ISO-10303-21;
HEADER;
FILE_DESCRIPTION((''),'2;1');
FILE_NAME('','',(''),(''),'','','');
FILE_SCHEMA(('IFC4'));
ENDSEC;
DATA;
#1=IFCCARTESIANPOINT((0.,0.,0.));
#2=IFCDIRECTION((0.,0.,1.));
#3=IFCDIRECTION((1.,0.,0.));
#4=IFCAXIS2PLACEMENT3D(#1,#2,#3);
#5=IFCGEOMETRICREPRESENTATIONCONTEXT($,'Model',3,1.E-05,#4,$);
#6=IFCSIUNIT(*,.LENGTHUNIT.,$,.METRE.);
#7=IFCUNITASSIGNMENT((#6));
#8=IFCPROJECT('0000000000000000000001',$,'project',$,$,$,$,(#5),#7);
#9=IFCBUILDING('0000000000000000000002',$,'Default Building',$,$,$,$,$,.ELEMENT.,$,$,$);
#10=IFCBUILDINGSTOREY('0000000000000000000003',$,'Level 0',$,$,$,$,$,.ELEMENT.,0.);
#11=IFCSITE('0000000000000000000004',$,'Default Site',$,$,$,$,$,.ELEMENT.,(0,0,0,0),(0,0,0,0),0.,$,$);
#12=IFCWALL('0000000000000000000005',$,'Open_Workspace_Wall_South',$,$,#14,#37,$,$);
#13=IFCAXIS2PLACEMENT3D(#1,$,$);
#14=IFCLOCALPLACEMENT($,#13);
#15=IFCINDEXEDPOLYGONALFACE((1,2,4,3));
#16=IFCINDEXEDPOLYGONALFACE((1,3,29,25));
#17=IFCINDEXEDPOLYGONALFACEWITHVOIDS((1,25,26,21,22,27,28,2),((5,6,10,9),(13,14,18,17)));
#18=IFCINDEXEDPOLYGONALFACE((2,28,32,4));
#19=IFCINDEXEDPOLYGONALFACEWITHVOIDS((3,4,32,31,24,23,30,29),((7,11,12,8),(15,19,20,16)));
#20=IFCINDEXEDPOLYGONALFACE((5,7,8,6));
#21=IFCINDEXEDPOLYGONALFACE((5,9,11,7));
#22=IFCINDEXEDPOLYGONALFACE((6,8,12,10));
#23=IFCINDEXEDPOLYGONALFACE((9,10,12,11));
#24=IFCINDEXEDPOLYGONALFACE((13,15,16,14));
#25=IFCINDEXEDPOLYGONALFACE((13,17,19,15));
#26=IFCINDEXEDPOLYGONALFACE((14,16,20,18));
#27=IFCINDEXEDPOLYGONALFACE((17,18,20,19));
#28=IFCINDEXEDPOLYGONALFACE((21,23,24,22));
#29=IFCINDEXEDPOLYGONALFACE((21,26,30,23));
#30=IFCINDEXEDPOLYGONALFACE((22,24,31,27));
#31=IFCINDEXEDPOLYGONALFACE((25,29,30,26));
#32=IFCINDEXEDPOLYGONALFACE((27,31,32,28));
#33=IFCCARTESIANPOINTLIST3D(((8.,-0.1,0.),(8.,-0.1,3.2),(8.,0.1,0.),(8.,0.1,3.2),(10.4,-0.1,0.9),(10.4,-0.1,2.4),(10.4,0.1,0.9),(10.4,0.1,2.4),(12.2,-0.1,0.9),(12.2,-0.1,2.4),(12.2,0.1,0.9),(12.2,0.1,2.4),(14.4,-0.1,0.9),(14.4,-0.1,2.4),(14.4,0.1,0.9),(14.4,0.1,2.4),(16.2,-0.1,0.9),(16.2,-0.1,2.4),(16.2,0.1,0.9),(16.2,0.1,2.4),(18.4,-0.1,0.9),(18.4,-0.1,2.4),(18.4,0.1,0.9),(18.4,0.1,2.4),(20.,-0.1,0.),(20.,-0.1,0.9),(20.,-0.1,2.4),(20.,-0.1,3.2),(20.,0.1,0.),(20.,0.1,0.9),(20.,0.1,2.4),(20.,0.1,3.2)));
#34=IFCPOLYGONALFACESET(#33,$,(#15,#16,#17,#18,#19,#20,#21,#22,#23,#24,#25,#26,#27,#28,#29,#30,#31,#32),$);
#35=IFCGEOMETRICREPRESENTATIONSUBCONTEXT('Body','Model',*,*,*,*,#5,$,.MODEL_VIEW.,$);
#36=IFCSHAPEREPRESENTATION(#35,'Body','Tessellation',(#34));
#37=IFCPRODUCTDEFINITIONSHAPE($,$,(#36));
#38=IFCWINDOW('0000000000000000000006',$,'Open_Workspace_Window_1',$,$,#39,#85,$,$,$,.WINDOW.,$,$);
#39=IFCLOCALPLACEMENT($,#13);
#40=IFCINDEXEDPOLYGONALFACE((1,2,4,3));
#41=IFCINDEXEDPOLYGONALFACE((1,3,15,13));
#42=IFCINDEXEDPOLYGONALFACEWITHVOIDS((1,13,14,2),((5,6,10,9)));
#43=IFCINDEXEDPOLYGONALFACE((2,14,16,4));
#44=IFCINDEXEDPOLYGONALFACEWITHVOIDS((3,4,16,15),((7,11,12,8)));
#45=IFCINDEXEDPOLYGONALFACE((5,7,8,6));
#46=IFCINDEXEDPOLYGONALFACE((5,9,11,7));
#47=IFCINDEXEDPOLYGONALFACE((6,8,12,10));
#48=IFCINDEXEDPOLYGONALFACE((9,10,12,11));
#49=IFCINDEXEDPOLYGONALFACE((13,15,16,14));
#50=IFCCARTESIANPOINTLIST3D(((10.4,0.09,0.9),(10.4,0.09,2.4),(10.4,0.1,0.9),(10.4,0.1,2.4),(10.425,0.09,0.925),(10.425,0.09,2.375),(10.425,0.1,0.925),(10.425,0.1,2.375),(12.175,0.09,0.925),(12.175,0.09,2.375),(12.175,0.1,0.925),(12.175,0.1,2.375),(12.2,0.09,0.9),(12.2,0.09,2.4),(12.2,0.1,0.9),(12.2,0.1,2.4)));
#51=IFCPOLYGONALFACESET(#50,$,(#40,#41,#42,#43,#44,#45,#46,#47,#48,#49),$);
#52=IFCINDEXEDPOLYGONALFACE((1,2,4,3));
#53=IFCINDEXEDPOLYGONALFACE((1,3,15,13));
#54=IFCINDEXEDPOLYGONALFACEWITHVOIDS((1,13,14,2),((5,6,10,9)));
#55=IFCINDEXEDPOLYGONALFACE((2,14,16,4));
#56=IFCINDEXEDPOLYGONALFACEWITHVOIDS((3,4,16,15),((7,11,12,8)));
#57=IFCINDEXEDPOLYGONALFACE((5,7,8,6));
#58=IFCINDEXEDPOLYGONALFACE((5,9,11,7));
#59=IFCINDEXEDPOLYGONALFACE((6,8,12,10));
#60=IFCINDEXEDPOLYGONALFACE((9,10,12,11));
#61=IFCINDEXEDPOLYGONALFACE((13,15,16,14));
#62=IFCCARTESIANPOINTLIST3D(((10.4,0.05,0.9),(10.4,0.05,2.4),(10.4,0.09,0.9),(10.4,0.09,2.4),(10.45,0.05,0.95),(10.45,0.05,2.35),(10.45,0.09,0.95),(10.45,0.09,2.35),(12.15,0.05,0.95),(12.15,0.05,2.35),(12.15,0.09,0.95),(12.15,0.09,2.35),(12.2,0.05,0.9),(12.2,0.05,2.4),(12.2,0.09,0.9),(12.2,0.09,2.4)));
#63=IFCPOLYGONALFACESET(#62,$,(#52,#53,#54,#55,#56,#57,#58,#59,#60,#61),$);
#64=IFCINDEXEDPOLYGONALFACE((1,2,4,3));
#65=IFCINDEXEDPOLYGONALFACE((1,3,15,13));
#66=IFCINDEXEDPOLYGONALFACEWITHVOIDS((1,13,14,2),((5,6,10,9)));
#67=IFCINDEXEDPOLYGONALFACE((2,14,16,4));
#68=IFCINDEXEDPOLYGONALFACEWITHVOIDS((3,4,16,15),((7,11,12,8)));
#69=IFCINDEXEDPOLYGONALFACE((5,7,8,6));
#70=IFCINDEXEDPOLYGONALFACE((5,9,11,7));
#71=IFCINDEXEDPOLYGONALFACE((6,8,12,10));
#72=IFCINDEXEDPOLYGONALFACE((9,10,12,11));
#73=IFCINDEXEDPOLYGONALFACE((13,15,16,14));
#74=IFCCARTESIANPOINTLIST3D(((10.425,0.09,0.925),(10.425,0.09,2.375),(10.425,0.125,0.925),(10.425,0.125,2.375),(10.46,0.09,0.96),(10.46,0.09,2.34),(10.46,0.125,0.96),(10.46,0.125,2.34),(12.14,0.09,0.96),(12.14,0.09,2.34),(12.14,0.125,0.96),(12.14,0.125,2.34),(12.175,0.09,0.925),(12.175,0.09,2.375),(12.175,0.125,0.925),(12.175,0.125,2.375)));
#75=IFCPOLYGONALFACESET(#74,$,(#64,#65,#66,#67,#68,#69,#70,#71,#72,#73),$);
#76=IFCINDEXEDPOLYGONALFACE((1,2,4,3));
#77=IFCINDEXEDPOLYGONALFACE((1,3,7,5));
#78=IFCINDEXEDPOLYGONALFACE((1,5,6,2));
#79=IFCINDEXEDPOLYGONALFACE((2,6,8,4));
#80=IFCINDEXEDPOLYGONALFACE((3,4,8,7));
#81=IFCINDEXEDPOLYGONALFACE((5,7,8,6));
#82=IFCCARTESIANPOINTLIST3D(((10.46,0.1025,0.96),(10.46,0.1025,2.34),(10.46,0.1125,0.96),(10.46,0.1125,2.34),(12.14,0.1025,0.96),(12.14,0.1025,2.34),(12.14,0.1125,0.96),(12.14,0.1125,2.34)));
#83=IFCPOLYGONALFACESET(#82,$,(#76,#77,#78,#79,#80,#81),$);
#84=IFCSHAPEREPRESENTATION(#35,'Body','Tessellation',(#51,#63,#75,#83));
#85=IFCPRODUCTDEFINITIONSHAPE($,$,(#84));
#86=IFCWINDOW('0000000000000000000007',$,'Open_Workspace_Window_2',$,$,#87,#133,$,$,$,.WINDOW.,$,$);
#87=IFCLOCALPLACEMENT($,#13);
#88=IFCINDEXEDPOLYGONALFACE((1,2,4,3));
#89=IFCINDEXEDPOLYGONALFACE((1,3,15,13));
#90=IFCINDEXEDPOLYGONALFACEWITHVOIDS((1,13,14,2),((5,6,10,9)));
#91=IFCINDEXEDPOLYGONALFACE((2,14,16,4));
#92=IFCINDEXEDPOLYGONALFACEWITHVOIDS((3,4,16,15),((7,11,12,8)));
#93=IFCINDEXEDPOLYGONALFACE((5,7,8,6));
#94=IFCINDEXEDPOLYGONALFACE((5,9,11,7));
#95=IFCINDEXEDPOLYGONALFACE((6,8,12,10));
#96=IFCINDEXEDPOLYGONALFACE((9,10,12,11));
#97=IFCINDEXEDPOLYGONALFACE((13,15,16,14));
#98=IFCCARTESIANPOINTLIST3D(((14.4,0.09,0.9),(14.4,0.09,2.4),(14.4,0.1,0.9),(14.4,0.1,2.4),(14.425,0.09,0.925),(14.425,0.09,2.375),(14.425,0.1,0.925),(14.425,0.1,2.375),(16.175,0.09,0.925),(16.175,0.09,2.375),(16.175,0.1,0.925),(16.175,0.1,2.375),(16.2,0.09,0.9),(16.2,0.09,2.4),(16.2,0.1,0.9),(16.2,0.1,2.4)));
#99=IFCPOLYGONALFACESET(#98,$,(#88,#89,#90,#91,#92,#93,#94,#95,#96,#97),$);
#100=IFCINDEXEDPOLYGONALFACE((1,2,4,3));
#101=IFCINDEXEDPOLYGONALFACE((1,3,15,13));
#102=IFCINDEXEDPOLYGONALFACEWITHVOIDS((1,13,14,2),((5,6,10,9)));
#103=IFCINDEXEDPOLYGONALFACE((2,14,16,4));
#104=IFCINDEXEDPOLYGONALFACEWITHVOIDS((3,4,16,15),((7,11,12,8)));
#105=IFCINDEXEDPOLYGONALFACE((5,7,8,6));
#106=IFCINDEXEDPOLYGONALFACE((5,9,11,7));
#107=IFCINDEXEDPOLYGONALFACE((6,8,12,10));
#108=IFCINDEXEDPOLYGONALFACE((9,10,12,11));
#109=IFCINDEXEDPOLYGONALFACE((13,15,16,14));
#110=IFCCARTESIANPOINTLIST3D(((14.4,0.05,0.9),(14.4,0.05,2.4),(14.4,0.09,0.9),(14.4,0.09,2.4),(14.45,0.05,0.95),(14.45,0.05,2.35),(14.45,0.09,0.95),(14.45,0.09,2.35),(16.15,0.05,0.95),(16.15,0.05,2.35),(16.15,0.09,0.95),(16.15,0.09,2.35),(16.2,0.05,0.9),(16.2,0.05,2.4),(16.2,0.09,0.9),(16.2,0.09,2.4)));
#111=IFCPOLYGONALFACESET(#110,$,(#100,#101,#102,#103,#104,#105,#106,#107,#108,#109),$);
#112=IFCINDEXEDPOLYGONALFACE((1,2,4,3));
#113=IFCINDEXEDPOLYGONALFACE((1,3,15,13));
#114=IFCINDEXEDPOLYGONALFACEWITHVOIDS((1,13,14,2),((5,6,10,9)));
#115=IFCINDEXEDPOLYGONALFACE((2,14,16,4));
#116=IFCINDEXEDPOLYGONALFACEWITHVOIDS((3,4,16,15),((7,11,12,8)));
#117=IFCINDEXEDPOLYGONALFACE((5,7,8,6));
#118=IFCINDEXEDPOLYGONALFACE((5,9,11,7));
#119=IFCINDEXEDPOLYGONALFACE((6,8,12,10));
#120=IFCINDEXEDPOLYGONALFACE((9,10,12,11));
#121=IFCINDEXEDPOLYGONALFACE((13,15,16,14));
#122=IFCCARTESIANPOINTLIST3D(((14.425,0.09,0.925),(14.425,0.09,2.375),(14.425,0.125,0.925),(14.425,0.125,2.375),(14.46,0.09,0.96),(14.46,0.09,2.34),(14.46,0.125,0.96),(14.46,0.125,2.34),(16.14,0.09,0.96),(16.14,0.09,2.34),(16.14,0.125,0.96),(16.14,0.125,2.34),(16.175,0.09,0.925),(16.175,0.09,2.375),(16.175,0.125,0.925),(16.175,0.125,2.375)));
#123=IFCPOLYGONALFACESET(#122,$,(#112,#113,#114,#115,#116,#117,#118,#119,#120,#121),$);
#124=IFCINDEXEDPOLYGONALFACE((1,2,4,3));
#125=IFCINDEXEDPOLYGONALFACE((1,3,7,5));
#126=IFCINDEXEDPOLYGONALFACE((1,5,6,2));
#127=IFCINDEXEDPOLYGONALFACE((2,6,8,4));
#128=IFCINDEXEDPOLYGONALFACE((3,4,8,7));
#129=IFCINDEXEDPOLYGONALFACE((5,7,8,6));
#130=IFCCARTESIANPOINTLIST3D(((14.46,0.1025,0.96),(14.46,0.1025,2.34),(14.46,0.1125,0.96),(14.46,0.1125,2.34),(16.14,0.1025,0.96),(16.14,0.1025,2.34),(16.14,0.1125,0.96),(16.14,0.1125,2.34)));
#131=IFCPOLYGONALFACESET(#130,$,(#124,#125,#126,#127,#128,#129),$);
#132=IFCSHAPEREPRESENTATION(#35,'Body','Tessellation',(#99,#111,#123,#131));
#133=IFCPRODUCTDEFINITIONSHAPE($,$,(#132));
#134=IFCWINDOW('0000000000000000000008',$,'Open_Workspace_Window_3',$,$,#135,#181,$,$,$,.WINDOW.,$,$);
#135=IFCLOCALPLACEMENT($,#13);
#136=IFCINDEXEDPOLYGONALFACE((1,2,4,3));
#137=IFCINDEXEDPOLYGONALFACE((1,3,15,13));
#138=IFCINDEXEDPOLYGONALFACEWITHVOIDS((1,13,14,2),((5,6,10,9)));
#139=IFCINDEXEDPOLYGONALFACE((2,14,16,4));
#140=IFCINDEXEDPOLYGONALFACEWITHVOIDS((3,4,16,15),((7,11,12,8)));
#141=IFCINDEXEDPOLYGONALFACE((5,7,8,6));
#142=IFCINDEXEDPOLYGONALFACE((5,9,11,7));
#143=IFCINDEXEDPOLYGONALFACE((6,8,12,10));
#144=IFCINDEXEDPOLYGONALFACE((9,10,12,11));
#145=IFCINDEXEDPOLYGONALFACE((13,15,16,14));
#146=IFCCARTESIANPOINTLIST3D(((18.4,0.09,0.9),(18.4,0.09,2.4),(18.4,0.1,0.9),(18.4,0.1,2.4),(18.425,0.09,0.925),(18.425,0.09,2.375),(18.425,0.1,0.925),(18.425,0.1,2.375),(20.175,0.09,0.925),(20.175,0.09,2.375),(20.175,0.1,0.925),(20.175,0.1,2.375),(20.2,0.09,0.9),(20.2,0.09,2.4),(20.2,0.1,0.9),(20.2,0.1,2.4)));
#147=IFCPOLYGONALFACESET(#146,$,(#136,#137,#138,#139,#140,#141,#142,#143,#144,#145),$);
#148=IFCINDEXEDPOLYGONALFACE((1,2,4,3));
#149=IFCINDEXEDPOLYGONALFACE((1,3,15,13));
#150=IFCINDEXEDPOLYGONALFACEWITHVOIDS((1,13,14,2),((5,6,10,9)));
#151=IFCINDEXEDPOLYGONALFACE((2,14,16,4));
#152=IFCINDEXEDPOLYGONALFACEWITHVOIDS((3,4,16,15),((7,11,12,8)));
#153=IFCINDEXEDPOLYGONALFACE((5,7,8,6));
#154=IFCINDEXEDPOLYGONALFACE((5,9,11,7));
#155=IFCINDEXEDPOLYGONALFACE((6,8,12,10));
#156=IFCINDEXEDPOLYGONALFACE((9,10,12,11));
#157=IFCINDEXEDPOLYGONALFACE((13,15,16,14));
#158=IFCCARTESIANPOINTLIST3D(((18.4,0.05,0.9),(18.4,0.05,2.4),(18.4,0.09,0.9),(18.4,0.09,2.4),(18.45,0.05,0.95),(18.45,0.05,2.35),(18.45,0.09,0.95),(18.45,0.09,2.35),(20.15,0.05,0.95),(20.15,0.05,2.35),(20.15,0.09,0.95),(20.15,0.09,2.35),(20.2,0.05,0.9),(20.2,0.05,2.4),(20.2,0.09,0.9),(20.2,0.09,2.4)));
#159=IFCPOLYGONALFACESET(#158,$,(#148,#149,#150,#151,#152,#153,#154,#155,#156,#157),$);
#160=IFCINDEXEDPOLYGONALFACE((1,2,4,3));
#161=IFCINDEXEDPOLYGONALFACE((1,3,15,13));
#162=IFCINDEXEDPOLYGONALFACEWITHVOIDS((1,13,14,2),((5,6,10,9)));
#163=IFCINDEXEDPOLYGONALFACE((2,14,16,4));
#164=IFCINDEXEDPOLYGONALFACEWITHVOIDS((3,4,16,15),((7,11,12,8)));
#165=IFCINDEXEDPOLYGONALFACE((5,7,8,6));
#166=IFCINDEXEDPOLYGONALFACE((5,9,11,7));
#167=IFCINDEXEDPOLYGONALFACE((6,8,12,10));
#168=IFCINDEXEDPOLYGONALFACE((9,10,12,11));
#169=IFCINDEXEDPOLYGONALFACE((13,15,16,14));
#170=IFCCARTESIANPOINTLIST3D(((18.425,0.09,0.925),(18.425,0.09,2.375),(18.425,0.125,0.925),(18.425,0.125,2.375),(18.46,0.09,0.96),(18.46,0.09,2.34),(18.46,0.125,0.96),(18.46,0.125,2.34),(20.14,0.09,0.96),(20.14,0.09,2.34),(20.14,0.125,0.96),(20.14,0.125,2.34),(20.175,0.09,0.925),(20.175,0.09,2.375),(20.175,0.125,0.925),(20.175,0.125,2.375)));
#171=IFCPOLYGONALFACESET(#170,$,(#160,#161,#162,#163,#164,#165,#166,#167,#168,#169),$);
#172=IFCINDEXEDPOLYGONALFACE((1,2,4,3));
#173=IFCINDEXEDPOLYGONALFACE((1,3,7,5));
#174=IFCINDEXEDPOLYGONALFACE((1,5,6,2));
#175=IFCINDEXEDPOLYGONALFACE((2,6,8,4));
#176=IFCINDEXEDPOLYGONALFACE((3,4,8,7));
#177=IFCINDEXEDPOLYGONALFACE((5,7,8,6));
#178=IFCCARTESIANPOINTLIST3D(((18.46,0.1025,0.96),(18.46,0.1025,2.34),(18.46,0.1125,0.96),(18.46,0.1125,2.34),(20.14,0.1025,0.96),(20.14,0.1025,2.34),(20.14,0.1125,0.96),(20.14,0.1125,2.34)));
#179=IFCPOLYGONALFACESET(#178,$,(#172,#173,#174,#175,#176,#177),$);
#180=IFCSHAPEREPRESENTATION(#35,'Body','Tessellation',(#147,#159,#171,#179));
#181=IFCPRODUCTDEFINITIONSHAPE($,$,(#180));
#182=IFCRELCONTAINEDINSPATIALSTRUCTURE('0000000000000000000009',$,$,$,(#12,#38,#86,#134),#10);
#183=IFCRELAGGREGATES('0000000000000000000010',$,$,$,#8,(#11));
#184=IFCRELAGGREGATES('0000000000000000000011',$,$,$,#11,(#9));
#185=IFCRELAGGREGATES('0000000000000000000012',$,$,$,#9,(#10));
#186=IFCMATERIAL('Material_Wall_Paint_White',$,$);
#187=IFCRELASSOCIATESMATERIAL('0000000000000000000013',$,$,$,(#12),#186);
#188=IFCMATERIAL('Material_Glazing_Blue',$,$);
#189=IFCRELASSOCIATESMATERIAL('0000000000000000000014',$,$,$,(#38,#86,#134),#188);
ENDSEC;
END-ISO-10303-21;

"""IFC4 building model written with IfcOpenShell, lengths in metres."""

from ifc_helpers import new_model, si_unit, frame, origin_with_axes, place, context, subcontext, project, spatial, line, indexed_curve, outline, extrude, material, element, fill, save


model = new_model("IFC4")

# Units and contexts
model_context = context("Model", 3, precision=1e-05, world=origin_with_axes())
body_context = subcontext(model_context, "Body", "Model", "MODEL_VIEW")
ifc_project = project(units=[si_unit("LENGTHUNIT", "METRE")], contexts=[model_context])

# Site, building, storey
site = spatial("IfcSite", under=ifc_project, Name="Default Site", CompositionType="ELEMENT", RefLatitude=(0, 0, 0, 0), RefLongitude=(0, 0, 0, 0), RefElevation=0.0)
building = spatial("IfcBuilding", under=site, Name="Default Building", CompositionType="ELEMENT")
storey = spatial("IfcBuildingStorey", under=building, Name="Level 0", CompositionType="ELEMENT", Elevation=0.0)

# Shared definitions
ifc_material_1 = material(Name="Material_Wall_Paint_White")

# Wall, openings, windows
wall_1_placement = place(None, frame((8.0, 0.0, 0.0), z_axis=(0.0, 0.0, 1.0), x_axis=(1.0, 0.0, 0.0)))
wall_1 = element("IfcWall", 1, at=wall_1_placement, inside=storey, material=ifc_material_1, Name="Open_Workspace_Wall_South", context=body_context, shape_type="SweptSolid", body=[
    extrude(outline(indexed_curve([(0.0, 0.0), (0.0, 0.2), (12.0, 0.2), (12.0, 0.0), (0.0, 0.0)], self_intersect=False)), frame((0.0, -0.1, 0.0), z_axis=(0.0, 0.0, 1.0), x_axis=(1.0, 0.0, 0.0)), (0.0, 0.0, 1.0), 3.2),
])
opening_1_placement = place(wall_1_placement, frame((2.4, -0.5, 0.9), z_axis=(0.0, 0.0, 1.0), x_axis=(1.0, 0.0, 0.0)))
opening_1 = element("IfcOpeningElement", 2, at=opening_1_placement, inside=storey, cuts=wall_1, PredefinedType="OPENING", context=body_context, shape_type="SweptSolid", body=[
    extrude(outline(indexed_curve([(0.0, 0.0), (0.0, 1.0), (1.8, 1.0), (1.8, 0.0), (0.0, 0.0)], self_intersect=False)), origin_with_axes(), (0.0, 0.0, 1.0), 1.5),
])
opening_2_placement = place(wall_1_placement, frame((6.4, -0.5, 0.9), z_axis=(0.0, 0.0, 1.0), x_axis=(1.0, 0.0, 0.0)))
opening_2 = element("IfcOpeningElement", 3, at=opening_2_placement, inside=storey, cuts=wall_1, PredefinedType="OPENING", context=body_context, shape_type="SweptSolid", body=[
    extrude(outline(indexed_curve([(0.0, 0.0), (0.0, 1.0), (1.8, 1.0), (1.8, 0.0), (0.0, 0.0)], self_intersect=False)), origin_with_axes(), (0.0, 0.0, 1.0), 1.5),
])
opening_3_placement = place(wall_1_placement, frame((10.4, -0.5, 0.9), z_axis=(0.0, 0.0, 1.0), x_axis=(1.0, 0.0, 0.0)))
opening_3 = element("IfcOpeningElement", 4, at=opening_3_placement, inside=storey, cuts=wall_1, PredefinedType="OPENING", context=body_context, shape_type="SweptSolid", body=[
    extrude(outline(indexed_curve([(0.0, 0.0), (0.0, 1.0), (1.8, 1.0), (1.8, 0.0), (0.0, 0.0)], self_intersect=False)), origin_with_axes(), (0.0, 0.0, 1.0), 1.5),
])
ifc_material_2 = material(Name="Material_Glazing_Blue")
window_1_placement = place(None, frame((10.4, 0.0, 0.9), z_axis=(0.0, 0.0, 1.0), x_axis=(1.0, 0.0, 0.0)))
window_1 = element("IfcWindow", 5, at=window_1_placement, inside=storey, material=ifc_material_2, Name="Open_Workspace_Window_1", PredefinedType="WINDOW", context=body_context, shape_type="SweptSolid", body=[
    extrude(outline(indexed_curve([(0.0, 0.0), (1.8, 0.0), (1.8, 1.5), (0.0, 1.5)], segments=[line(1, 2, 3, 4, 1)]), holes=[indexed_curve([(0.025, 0.025), (1.775, 0.025), (1.775, 1.475), (0.025, 1.475)], segments=[line(1, 2, 3, 4, 1)])]), frame((0.0, 0.09, 0.0), z_axis=(0.0, -1.0, 0.0), x_axis=(1.0, 0.0, 0.0)), (0.0, 0.0, -1.0), 0.01),
    extrude(outline(indexed_curve([(0.0, 0.0), (1.8, 0.0), (1.8, 1.5), (0.0, 1.5)], segments=[line(1, 2, 3, 4, 1)]), holes=[indexed_curve([(0.05, 0.05), (1.75, 0.05), (1.75, 1.45), (0.05, 1.45)], segments=[line(1, 2, 3, 4, 1)])]), frame((0.0, 0.05, 0.0), z_axis=(0.0, -1.0, 0.0), x_axis=(1.0, 0.0, 0.0)), (0.0, 0.0, -1.0), 0.04),
    extrude(outline(indexed_curve([(0.0, 0.0), (1.75, 0.0), (1.75, 1.45), (0.0, 1.45)], segments=[line(1, 2, 3, 4, 1)]), holes=[indexed_curve([(0.035, 0.035), (1.715, 0.035), (1.715, 1.415), (0.035, 1.415)], segments=[line(1, 2, 3, 4, 1)])]), frame((0.025, 0.09, 0.025), z_axis=(0.0, -1.0, 0.0), x_axis=(1.0, 0.0, 0.0)), (0.0, 0.0, -1.0), 0.035),
    extrude(outline(indexed_curve([(0.035, 0.035), (1.715, 0.035), (1.715, 1.415), (0.035, 1.415)], segments=[line(1, 2, 3, 4, 1)])), frame((0.025, 0.1025, 0.025), z_axis=(0.0, -1.0, 0.0), x_axis=(1.0, 0.0, 0.0)), (0.0, 0.0, -1.0), 0.01),
])
fill(opening_1, window_1)
window_2_placement = place(None, frame((14.4, 0.0, 0.9), z_axis=(0.0, 0.0, 1.0), x_axis=(1.0, 0.0, 0.0)))
window_2 = element("IfcWindow", 6, at=window_2_placement, inside=storey, material=ifc_material_2, Name="Open_Workspace_Window_2", PredefinedType="WINDOW", context=body_context, shape_type="SweptSolid", body=[
    extrude(outline(indexed_curve([(0.0, 0.0), (1.8, 0.0), (1.8, 1.5), (0.0, 1.5)], segments=[line(1, 2, 3, 4, 1)]), holes=[indexed_curve([(0.025, 0.025), (1.775, 0.025), (1.775, 1.475), (0.025, 1.475)], segments=[line(1, 2, 3, 4, 1)])]), frame((0.0, 0.09, 0.0), z_axis=(0.0, -1.0, 0.0), x_axis=(1.0, 0.0, 0.0)), (0.0, 0.0, -1.0), 0.01),
    extrude(outline(indexed_curve([(0.0, 0.0), (1.8, 0.0), (1.8, 1.5), (0.0, 1.5)], segments=[line(1, 2, 3, 4, 1)]), holes=[indexed_curve([(0.05, 0.05), (1.75, 0.05), (1.75, 1.45), (0.05, 1.45)], segments=[line(1, 2, 3, 4, 1)])]), frame((0.0, 0.05, 0.0), z_axis=(0.0, -1.0, 0.0), x_axis=(1.0, 0.0, 0.0)), (0.0, 0.0, -1.0), 0.04),
    extrude(outline(indexed_curve([(0.0, 0.0), (1.75, 0.0), (1.75, 1.45), (0.0, 1.45)], segments=[line(1, 2, 3, 4, 1)]), holes=[indexed_curve([(0.035, 0.035), (1.715, 0.035), (1.715, 1.415), (0.035, 1.415)], segments=[line(1, 2, 3, 4, 1)])]), frame((0.025, 0.09, 0.025), z_axis=(0.0, -1.0, 0.0), x_axis=(1.0, 0.0, 0.0)), (0.0, 0.0, -1.0), 0.035),
    extrude(outline(indexed_curve([(0.035, 0.035), (1.715, 0.035), (1.715, 1.415), (0.035, 1.415)], segments=[line(1, 2, 3, 4, 1)])), frame((0.025, 0.1025, 0.025), z_axis=(0.0, -1.0, 0.0), x_axis=(1.0, 0.0, 0.0)), (0.0, 0.0, -1.0), 0.01),
])
fill(opening_2, window_2)
window_3_placement = place(None, frame((18.4, 0.0, 0.9), z_axis=(0.0, 0.0, 1.0), x_axis=(1.0, 0.0, 0.0)))
window_3 = element("IfcWindow", 7, at=window_3_placement, inside=storey, material=ifc_material_2, Name="Open_Workspace_Window_3", PredefinedType="WINDOW", context=body_context, shape_type="SweptSolid", body=[
    extrude(outline(indexed_curve([(0.0, 0.0), (1.8, 0.0), (1.8, 1.5), (0.0, 1.5)], segments=[line(1, 2, 3, 4, 1)]), holes=[indexed_curve([(0.025, 0.025), (1.775, 0.025), (1.775, 1.475), (0.025, 1.475)], segments=[line(1, 2, 3, 4, 1)])]), frame((0.0, 0.09, 0.0), z_axis=(0.0, -1.0, 0.0), x_axis=(1.0, 0.0, 0.0)), (0.0, 0.0, -1.0), 0.01),
    extrude(outline(indexed_curve([(0.0, 0.0), (1.8, 0.0), (1.8, 1.5), (0.0, 1.5)], segments=[line(1, 2, 3, 4, 1)]), holes=[indexed_curve([(0.05, 0.05), (1.75, 0.05), (1.75, 1.45), (0.05, 1.45)], segments=[line(1, 2, 3, 4, 1)])]), frame((0.0, 0.05, 0.0), z_axis=(0.0, -1.0, 0.0), x_axis=(1.0, 0.0, 0.0)), (0.0, 0.0, -1.0), 0.04),
    extrude(outline(indexed_curve([(0.0, 0.0), (1.75, 0.0), (1.75, 1.45), (0.0, 1.45)], segments=[line(1, 2, 3, 4, 1)]), holes=[indexed_curve([(0.035, 0.035), (1.715, 0.035), (1.715, 1.415), (0.035, 1.415)], segments=[line(1, 2, 3, 4, 1)])]), frame((0.025, 0.09, 0.025), z_axis=(0.0, -1.0, 0.0), x_axis=(1.0, 0.0, 0.0)), (0.0, 0.0, -1.0), 0.035),
    extrude(outline(indexed_curve([(0.035, 0.035), (1.715, 0.035), (1.715, 1.415), (0.035, 1.415)], segments=[line(1, 2, 3, 4, 1)])), frame((0.025, 0.1025, 0.025), z_axis=(0.0, -1.0, 0.0), x_axis=(1.0, 0.0, 0.0)), (0.0, 0.0, -1.0), 0.01),
])
fill(opening_3, window_3)

save(model, "model.ifc")
